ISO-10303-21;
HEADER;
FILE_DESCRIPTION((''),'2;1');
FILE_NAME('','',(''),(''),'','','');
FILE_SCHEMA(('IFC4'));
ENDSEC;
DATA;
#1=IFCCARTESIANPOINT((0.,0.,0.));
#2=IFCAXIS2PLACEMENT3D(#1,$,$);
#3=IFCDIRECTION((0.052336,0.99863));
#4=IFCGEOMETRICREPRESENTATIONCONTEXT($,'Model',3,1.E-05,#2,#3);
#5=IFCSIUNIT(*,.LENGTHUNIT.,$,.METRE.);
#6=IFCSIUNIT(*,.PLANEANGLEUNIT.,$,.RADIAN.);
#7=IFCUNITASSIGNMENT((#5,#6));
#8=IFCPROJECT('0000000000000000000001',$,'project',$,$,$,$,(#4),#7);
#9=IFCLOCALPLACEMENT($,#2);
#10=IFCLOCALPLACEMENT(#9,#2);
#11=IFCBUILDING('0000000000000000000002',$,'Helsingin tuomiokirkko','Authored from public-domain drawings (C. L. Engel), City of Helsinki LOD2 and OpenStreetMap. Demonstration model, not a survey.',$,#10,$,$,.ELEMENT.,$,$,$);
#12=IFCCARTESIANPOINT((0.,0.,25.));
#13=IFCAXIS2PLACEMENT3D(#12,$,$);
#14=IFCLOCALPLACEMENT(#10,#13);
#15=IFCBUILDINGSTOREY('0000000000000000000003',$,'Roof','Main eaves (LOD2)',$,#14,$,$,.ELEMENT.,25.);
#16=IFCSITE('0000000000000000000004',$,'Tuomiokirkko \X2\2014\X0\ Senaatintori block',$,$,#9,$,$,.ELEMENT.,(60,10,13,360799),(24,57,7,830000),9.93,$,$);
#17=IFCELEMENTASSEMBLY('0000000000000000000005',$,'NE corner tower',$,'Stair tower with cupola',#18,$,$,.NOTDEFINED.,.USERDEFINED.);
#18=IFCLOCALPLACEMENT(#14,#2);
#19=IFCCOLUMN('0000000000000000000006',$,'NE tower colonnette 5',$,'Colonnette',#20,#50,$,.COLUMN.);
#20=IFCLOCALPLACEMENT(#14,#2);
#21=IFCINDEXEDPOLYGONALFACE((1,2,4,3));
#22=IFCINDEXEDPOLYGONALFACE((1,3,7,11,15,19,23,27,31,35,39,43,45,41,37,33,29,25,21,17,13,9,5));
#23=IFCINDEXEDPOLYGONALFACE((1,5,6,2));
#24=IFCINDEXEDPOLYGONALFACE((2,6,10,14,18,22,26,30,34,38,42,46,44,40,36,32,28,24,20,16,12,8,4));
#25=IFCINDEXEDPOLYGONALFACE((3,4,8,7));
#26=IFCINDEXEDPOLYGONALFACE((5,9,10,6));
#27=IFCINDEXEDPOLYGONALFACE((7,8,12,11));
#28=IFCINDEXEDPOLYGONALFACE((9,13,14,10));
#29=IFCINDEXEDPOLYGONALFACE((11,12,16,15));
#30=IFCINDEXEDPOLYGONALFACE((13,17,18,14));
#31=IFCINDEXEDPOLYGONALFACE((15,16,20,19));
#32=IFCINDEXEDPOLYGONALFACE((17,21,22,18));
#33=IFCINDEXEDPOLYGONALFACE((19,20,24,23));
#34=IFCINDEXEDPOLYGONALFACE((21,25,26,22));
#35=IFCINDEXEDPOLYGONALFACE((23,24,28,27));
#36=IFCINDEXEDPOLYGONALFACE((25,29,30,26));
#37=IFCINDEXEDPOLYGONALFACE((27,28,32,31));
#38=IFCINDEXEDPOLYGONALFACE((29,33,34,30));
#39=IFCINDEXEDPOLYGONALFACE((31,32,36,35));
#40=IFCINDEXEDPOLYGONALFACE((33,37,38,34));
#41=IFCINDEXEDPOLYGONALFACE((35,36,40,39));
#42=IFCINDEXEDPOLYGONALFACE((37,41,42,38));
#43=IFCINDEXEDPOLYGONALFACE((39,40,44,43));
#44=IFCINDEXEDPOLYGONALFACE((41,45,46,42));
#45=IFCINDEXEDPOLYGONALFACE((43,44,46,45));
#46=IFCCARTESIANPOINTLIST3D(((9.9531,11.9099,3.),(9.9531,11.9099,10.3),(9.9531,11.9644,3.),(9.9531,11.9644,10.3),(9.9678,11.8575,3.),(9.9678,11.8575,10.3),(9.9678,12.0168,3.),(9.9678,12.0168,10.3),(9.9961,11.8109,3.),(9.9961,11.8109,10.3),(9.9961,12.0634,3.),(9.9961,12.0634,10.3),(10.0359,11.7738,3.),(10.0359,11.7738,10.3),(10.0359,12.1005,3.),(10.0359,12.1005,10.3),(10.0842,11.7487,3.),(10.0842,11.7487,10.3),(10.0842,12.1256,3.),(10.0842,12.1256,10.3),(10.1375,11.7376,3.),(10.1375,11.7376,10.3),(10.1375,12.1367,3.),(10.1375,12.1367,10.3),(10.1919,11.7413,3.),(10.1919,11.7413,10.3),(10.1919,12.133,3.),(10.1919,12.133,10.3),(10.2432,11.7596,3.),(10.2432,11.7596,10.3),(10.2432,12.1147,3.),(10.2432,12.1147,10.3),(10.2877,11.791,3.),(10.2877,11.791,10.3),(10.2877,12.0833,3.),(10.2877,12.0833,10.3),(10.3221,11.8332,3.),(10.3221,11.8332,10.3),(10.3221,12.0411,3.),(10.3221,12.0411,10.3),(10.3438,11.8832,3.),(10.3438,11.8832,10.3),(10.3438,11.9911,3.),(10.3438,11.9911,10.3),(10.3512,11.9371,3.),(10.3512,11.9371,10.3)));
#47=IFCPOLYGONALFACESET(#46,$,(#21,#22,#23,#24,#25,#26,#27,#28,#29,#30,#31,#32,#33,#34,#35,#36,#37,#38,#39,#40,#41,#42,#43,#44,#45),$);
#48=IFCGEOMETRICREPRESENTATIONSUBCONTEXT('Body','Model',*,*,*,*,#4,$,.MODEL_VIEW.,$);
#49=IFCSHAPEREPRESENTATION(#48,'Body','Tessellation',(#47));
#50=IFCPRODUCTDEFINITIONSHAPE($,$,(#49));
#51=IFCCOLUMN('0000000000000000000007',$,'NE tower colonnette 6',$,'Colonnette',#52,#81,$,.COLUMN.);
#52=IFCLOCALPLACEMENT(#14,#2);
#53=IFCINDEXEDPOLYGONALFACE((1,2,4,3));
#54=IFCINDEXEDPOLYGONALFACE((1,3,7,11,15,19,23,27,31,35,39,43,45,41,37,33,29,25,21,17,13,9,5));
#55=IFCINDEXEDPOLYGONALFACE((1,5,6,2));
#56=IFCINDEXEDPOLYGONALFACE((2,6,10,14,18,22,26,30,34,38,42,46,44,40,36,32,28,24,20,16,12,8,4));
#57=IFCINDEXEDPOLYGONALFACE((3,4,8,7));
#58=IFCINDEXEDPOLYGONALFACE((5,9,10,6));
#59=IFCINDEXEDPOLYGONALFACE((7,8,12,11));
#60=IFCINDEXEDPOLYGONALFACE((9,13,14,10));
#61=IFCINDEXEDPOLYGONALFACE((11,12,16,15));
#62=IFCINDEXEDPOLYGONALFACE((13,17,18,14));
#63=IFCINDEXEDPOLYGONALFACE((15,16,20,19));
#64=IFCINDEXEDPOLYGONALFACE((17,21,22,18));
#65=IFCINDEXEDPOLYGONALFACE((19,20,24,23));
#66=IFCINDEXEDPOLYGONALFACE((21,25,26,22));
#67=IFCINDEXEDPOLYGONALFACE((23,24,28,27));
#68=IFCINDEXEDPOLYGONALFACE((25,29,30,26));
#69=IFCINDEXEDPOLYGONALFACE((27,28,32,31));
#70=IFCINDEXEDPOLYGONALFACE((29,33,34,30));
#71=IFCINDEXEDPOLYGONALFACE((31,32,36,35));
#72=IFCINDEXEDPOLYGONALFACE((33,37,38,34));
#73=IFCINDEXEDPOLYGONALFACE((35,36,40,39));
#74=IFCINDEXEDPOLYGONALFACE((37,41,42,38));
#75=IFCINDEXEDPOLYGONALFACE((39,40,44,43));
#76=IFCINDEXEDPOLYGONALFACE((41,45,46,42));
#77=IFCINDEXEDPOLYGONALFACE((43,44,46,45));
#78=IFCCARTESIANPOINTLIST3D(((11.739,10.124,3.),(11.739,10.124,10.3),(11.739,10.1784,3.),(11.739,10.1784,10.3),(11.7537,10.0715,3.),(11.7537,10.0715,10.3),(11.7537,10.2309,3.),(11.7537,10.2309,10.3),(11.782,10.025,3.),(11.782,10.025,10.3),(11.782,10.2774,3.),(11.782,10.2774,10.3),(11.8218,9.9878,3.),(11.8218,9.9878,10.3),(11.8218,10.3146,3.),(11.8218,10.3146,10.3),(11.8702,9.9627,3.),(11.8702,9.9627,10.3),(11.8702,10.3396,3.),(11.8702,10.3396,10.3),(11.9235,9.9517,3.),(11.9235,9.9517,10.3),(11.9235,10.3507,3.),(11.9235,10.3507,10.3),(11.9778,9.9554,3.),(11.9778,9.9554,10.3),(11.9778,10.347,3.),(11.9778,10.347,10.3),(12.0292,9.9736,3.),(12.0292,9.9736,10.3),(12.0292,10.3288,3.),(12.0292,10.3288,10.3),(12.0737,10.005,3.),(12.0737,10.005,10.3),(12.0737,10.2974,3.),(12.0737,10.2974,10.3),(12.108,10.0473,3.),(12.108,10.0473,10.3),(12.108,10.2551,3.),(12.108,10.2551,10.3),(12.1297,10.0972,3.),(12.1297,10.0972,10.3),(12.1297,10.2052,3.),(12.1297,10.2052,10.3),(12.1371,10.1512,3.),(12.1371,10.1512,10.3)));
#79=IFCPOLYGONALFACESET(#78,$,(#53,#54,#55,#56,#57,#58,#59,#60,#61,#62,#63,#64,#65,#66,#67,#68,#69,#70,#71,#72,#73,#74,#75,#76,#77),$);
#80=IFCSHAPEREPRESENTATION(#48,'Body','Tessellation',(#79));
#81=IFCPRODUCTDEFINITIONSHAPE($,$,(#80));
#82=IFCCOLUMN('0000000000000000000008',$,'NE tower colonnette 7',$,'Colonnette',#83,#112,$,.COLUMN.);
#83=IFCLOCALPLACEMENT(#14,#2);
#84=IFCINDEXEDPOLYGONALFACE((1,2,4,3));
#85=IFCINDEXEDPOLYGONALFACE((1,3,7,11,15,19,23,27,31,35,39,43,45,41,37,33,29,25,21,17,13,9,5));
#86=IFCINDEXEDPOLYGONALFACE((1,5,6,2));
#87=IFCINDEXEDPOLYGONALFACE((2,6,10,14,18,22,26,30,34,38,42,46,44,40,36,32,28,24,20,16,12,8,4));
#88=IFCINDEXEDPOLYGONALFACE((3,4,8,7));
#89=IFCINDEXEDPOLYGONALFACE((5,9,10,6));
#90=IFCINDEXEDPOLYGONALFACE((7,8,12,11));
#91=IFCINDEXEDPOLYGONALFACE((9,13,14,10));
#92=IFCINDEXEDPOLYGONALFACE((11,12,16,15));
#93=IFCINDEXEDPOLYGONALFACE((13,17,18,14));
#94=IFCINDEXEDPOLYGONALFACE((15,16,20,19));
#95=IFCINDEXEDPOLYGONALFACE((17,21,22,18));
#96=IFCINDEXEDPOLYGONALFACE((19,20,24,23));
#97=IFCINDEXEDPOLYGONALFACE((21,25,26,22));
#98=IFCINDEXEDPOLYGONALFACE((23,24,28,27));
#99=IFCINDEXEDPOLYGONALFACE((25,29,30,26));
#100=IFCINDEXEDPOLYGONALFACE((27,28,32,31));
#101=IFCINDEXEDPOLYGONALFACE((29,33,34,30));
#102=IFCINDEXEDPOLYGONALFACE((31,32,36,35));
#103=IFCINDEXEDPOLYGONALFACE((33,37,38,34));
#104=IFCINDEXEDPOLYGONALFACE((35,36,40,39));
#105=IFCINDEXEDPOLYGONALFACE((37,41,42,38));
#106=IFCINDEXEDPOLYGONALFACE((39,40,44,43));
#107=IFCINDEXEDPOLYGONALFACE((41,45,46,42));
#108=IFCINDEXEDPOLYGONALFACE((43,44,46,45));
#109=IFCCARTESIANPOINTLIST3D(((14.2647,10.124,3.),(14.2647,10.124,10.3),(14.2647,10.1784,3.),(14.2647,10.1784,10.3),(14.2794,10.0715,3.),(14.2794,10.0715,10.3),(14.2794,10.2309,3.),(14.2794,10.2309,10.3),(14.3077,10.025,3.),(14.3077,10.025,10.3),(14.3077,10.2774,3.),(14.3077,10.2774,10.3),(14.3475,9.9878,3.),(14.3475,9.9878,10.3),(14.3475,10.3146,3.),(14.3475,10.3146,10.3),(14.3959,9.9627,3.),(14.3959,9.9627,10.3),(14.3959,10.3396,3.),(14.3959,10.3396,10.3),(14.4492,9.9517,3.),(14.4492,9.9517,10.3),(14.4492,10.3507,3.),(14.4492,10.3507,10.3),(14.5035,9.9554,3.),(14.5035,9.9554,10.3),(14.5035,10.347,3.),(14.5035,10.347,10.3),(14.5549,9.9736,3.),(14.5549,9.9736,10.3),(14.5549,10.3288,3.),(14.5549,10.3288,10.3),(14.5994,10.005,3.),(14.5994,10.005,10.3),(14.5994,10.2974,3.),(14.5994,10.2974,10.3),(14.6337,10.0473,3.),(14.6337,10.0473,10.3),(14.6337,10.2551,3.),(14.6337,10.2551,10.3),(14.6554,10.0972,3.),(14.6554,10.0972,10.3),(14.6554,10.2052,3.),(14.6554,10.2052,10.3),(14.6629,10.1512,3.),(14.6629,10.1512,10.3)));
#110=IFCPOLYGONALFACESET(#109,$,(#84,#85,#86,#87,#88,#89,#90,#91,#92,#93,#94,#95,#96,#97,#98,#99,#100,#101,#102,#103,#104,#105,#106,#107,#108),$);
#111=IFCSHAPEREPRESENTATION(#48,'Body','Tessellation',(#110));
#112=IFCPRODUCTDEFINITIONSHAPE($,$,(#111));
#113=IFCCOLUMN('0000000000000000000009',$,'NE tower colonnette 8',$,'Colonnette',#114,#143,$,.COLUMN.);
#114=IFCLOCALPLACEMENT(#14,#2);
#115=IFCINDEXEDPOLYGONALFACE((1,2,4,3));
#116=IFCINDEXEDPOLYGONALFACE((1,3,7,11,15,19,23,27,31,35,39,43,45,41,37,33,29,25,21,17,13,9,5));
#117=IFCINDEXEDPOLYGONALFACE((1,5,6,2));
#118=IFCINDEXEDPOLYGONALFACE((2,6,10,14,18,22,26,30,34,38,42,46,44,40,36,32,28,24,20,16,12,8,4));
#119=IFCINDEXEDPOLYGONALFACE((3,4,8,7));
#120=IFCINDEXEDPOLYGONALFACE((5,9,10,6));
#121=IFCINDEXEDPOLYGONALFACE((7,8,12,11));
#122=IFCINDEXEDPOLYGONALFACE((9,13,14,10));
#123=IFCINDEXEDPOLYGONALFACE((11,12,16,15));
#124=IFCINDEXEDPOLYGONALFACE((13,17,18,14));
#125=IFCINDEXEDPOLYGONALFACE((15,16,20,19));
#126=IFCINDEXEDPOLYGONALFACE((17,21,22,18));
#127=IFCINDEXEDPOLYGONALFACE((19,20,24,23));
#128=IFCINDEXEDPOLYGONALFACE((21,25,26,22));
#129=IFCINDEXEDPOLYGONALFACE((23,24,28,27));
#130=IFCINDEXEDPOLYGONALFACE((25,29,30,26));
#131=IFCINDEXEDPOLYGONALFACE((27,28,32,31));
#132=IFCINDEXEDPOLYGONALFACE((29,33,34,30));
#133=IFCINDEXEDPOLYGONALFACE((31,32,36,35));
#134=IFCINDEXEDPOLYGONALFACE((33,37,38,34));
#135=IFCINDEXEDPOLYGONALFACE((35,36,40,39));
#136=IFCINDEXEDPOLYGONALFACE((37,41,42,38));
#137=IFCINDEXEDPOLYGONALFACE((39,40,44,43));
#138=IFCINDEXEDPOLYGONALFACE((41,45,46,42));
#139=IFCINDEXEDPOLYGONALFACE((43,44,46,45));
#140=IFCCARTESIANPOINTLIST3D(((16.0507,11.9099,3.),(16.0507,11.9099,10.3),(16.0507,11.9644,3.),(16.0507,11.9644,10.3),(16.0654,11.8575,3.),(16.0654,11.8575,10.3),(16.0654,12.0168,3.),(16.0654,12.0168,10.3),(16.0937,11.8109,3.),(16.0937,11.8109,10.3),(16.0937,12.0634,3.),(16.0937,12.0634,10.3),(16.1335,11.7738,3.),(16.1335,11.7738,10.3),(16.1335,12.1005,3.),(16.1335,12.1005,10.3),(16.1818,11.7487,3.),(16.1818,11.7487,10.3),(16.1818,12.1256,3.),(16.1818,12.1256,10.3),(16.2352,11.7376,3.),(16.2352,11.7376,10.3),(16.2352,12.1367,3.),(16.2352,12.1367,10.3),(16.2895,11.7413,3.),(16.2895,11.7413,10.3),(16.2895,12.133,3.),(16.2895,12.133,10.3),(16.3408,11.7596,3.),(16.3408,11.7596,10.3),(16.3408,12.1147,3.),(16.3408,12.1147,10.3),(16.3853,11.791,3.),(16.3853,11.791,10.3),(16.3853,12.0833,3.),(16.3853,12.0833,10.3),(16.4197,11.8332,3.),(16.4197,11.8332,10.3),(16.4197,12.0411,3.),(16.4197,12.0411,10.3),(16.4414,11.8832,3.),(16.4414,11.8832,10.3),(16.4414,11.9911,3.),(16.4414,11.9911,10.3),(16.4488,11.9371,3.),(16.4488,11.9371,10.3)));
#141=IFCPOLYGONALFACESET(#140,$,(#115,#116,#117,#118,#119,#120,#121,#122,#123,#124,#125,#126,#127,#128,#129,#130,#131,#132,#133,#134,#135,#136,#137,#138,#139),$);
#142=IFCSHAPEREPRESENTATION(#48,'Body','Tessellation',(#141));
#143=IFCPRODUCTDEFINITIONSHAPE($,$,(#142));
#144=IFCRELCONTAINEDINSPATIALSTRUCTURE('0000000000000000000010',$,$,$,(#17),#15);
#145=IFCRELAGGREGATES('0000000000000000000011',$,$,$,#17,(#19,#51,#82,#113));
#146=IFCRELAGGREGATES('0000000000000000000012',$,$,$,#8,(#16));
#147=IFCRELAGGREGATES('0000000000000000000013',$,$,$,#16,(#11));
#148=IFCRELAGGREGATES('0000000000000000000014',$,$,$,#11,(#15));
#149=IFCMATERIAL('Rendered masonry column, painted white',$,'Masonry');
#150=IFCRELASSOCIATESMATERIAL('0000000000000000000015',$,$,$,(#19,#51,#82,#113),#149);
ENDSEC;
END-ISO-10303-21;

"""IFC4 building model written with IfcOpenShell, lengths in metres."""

from ifc_helpers import new_model, si_unit, direction, frame, origin, origin_2d_with_axis, place, context, subcontext, project, spatial, circle, extrude, material, element, aggregate, save


model = new_model("IFC4")

# Units and contexts
model_context = context("Model", 3, precision=1e-05, world=origin(), true_north=direction((0.052336, 0.99863)))
body_context = subcontext(model_context, "Body", "Model", "MODEL_VIEW")
ifc_project = project(units=[si_unit("LENGTHUNIT", "METRE"), si_unit("PLANEANGLEUNIT", "RADIAN")], contexts=[model_context])

# Site, building, storey
site_placement = place(None, origin())
site = spatial("IfcSite", under=ifc_project, at=site_placement, Name="Tuomiokirkko — Senaatintori block", CompositionType="ELEMENT", RefLatitude=(60, 10, 13, 360799), RefLongitude=(24, 57, 7, 830000), RefElevation=9.93)
building_placement = place(site_placement, origin())
building = spatial("IfcBuilding", under=site, at=building_placement, Name="Helsingin tuomiokirkko", Description="Authored from public-domain drawings (C. L. Engel), City of Helsinki LOD2 and OpenStreetMap. Demonstration model, not a survey.", CompositionType="ELEMENT")
storey_placement = place(building_placement, frame((0.0, 0.0, 25.0)))
storey = spatial("IfcBuildingStorey", under=building, at=storey_placement, Name="Roof", Description="Main eaves (LOD2)", CompositionType="ELEMENT", Elevation=25.0)

# Element assembly, columns
ifc_material_1 = material(Name="Rendered masonry column, painted white", Category="Masonry")
assembly_1_placement = place(building_placement, origin())
assembly_1 = element("IfcElementAssembly", 1, at=assembly_1_placement, inside=storey, Name="NE corner tower", ObjectType="Stair tower with cupola", AssemblyPlace="NOTDEFINED", PredefinedType="USERDEFINED")
column_1_placement = place(building_placement, origin())
column_1 = element("IfcColumn", 2, at=column_1_placement, material=ifc_material_1, Name="NE tower colonnette 5", ObjectType="Colonnette", PredefinedType="COLUMN", context=body_context, shape_type="SweptSolid", body=[
    extrude(circle(Radius=0.2, at=origin_2d_with_axis()), frame((10.1512, 11.9371, 28.0)), (0.0, 0.0, 1.0), 7.3),
])
column_2_placement = place(building_placement, origin())
column_2 = element("IfcColumn", 3, at=column_2_placement, material=ifc_material_1, Name="NE tower colonnette 6", ObjectType="Colonnette", PredefinedType="COLUMN", context=body_context, shape_type="SweptSolid", body=[
    extrude(circle(Radius=0.2, at=origin_2d_with_axis()), frame((11.9371, 10.1512, 28.0)), (0.0, 0.0, 1.0), 7.3),
])
column_3_placement = place(building_placement, origin())
column_3 = element("IfcColumn", 4, at=column_3_placement, material=ifc_material_1, Name="NE tower colonnette 7", ObjectType="Colonnette", PredefinedType="COLUMN", context=body_context, shape_type="SweptSolid", body=[
    extrude(circle(Radius=0.2, at=origin_2d_with_axis()), frame((14.4629, 10.1512, 28.0)), (0.0, 0.0, 1.0), 7.3),
])
column_4_placement = place(building_placement, origin())
column_4 = element("IfcColumn", 5, at=column_4_placement, material=ifc_material_1, Name="NE tower colonnette 8", ObjectType="Colonnette", PredefinedType="COLUMN", context=body_context, shape_type="SweptSolid", body=[
    extrude(circle(Radius=0.2, at=origin_2d_with_axis()), frame((16.2488, 11.9371, 28.0)), (0.0, 0.0, 1.0), 7.3),
])

aggregate(assembly_1, [column_1, column_2, column_3, column_4])

save(model, "model.ifc")
